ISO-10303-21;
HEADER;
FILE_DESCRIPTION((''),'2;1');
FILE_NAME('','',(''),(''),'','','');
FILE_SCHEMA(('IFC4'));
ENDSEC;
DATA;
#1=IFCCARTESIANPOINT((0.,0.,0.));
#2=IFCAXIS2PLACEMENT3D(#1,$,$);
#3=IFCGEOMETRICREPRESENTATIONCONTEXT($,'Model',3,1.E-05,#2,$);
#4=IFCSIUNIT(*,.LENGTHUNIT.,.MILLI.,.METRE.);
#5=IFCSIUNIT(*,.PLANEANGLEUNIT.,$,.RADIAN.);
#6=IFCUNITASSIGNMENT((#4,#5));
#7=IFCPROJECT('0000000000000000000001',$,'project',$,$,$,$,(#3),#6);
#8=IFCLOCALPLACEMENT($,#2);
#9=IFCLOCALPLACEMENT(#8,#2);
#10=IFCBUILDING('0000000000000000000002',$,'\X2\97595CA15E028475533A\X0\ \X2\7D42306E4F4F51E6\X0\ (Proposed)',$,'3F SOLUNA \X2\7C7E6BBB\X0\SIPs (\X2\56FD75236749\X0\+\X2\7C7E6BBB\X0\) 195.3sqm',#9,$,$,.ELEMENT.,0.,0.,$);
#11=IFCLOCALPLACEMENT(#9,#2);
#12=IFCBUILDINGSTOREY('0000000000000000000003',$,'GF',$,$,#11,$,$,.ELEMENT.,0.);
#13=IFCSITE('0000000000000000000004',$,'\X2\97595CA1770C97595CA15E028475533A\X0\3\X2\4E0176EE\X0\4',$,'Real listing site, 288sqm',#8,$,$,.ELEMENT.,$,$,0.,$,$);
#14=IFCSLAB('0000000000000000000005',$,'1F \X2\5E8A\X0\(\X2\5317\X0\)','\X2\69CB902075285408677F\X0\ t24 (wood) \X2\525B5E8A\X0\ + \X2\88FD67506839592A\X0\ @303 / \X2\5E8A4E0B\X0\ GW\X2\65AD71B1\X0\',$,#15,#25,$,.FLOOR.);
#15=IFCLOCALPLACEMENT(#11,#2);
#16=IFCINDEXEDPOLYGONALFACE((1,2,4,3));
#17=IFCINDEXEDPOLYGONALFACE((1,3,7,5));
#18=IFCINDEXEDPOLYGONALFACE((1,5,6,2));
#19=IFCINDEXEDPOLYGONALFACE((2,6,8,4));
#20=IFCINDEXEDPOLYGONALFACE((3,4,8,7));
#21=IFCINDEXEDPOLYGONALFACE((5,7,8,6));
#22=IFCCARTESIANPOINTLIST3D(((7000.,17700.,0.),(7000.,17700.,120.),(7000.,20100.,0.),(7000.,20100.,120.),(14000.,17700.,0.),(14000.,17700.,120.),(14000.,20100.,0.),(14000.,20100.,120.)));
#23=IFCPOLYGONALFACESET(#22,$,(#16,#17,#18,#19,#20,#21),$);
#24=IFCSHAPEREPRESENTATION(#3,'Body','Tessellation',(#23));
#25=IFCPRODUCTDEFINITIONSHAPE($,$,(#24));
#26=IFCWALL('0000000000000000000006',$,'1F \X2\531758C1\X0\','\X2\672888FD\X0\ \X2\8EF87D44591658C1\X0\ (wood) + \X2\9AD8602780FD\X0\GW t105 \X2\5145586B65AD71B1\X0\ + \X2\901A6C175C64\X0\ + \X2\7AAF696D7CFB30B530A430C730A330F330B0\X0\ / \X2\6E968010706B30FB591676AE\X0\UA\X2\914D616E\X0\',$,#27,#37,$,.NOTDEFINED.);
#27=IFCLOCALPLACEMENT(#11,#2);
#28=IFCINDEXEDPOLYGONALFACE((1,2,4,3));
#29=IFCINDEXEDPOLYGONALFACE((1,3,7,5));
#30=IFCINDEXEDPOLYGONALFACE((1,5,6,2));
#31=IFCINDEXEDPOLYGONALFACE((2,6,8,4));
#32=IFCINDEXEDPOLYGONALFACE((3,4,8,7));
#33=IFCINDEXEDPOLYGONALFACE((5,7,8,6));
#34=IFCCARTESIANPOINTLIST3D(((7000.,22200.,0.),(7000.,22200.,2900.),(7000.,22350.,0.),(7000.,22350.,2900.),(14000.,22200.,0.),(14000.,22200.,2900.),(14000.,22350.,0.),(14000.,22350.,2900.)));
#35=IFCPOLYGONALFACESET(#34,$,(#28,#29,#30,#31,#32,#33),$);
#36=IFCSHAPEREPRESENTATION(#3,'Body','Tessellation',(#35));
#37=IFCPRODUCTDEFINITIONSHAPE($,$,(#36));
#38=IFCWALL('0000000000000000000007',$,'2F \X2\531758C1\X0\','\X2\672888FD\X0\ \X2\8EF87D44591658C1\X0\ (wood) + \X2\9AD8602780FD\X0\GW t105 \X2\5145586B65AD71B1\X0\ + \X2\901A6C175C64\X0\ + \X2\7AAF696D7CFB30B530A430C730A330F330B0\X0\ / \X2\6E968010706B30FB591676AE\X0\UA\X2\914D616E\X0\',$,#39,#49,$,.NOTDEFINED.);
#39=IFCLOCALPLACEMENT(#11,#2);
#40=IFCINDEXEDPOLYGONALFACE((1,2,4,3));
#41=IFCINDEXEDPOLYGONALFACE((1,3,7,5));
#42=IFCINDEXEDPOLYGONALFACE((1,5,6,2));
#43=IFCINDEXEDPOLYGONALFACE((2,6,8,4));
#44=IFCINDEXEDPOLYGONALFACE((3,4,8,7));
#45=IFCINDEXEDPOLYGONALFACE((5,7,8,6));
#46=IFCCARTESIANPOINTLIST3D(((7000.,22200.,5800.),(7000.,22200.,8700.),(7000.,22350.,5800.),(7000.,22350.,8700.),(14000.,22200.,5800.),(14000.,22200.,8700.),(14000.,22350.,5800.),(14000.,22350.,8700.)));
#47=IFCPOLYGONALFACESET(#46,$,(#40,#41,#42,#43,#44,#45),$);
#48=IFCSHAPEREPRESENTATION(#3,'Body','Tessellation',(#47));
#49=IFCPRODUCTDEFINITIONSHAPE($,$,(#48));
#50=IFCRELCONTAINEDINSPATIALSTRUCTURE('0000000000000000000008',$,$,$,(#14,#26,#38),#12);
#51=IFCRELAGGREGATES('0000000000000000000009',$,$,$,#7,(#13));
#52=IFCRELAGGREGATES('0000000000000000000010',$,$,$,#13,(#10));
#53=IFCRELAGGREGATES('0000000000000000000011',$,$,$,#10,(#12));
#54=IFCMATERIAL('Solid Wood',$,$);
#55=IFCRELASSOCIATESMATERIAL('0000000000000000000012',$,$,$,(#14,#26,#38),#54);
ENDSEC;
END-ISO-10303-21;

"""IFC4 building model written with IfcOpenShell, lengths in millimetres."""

from ifc_helpers import new_model, si_unit, frame, frame_2d, origin, place, context, project, spatial, rectangle, extrude, material, element, save


model = new_model("IFC4")

# Units and contexts
model_context = context("Model", 3, precision=1e-05, world=origin())
ifc_project = project(units=[si_unit("LENGTHUNIT", "METRE", prefix="MILLI"), si_unit("PLANEANGLEUNIT", "RADIAN")], contexts=[model_context])

# Site, building, storey
site_placement = place(None, origin())
site = spatial("IfcSite", under=ifc_project, at=site_placement, Name="静岡県静岡市葵区3丁目4", ObjectType="Real listing site, 288sqm", CompositionType="ELEMENT", RefElevation=0.0)
building_placement = place(site_placement, origin())
building = spatial("IfcBuilding", under=site, at=building_placement, Name="静岡市葵区 終の住処 (Proposed)", ObjectType="3F SOLUNA 籾殻SIPs (国産杉+籾殻) 195.3sqm", CompositionType="ELEMENT", ElevationOfRefHeight=0.0, ElevationOfTerrain=0.0)
storey_placement = place(building_placement, origin())
storey = spatial("IfcBuildingStorey", under=building, at=storey_placement, Name="GF", CompositionType="ELEMENT", Elevation=0.0)

# Slab
ifc_material_1 = material(Name="Solid Wood")
slab_1_placement = place(storey_placement, frame((3500.0, 8850.0, 0.0)))
element("IfcSlab", 1, at=slab_1_placement, inside=storey, material=ifc_material_1, Name="1F 床(北)", Description="構造用合板 t24 (wood) 剛床 + 製材根太 @303 / 床下 GW断熱", PredefinedType="FLOOR", context=model_context, shape_type="SweptSolid", body=[
    extrude(rectangle(XDim=7000.0, YDim=2400.0, at=frame_2d((3500.0, 1200.0))), frame((3500.0, 8850.0, 0.0)), (0.0, 0.0, 1.0), 120.0),
])

# Wall
wall_1_placement = place(storey_placement, frame((3500.0, 11100.0, 0.0)))
element("IfcWall", 2, at=wall_1_placement, inside=storey, material=ifc_material_1, Name="1F 北壁", Description="木製 軸組外壁 (wood) + 高性能GW t105 充填断熱 + 通気層 + 窯業系サイディング / 準耐火・外皮UA配慮", PredefinedType="NOTDEFINED", context=model_context, shape_type="SweptSolid", body=[
    extrude(rectangle(XDim=7000.0, YDim=150.0, at=frame_2d((3500.0, 75.0))), frame((3500.0, 11100.0, 0.0)), (0.0, 0.0, 1.0), 2900.0),
])

# Wall
wall_2_placement = place(storey_placement, frame((3500.0, 11100.0, 2900.0)))
element("IfcWall", 3, at=wall_2_placement, inside=storey, material=ifc_material_1, Name="2F 北壁", Description="木製 軸組外壁 (wood) + 高性能GW t105 充填断熱 + 通気層 + 窯業系サイディング / 準耐火・外皮UA配慮", PredefinedType="NOTDEFINED", context=model_context, shape_type="SweptSolid", body=[
    extrude(rectangle(XDim=7000.0, YDim=150.0, at=frame_2d((3500.0, 75.0))), frame((3500.0, 11100.0, 2900.0)), (0.0, 0.0, 1.0), 2900.0),
])

save(model, "model.ifc")
